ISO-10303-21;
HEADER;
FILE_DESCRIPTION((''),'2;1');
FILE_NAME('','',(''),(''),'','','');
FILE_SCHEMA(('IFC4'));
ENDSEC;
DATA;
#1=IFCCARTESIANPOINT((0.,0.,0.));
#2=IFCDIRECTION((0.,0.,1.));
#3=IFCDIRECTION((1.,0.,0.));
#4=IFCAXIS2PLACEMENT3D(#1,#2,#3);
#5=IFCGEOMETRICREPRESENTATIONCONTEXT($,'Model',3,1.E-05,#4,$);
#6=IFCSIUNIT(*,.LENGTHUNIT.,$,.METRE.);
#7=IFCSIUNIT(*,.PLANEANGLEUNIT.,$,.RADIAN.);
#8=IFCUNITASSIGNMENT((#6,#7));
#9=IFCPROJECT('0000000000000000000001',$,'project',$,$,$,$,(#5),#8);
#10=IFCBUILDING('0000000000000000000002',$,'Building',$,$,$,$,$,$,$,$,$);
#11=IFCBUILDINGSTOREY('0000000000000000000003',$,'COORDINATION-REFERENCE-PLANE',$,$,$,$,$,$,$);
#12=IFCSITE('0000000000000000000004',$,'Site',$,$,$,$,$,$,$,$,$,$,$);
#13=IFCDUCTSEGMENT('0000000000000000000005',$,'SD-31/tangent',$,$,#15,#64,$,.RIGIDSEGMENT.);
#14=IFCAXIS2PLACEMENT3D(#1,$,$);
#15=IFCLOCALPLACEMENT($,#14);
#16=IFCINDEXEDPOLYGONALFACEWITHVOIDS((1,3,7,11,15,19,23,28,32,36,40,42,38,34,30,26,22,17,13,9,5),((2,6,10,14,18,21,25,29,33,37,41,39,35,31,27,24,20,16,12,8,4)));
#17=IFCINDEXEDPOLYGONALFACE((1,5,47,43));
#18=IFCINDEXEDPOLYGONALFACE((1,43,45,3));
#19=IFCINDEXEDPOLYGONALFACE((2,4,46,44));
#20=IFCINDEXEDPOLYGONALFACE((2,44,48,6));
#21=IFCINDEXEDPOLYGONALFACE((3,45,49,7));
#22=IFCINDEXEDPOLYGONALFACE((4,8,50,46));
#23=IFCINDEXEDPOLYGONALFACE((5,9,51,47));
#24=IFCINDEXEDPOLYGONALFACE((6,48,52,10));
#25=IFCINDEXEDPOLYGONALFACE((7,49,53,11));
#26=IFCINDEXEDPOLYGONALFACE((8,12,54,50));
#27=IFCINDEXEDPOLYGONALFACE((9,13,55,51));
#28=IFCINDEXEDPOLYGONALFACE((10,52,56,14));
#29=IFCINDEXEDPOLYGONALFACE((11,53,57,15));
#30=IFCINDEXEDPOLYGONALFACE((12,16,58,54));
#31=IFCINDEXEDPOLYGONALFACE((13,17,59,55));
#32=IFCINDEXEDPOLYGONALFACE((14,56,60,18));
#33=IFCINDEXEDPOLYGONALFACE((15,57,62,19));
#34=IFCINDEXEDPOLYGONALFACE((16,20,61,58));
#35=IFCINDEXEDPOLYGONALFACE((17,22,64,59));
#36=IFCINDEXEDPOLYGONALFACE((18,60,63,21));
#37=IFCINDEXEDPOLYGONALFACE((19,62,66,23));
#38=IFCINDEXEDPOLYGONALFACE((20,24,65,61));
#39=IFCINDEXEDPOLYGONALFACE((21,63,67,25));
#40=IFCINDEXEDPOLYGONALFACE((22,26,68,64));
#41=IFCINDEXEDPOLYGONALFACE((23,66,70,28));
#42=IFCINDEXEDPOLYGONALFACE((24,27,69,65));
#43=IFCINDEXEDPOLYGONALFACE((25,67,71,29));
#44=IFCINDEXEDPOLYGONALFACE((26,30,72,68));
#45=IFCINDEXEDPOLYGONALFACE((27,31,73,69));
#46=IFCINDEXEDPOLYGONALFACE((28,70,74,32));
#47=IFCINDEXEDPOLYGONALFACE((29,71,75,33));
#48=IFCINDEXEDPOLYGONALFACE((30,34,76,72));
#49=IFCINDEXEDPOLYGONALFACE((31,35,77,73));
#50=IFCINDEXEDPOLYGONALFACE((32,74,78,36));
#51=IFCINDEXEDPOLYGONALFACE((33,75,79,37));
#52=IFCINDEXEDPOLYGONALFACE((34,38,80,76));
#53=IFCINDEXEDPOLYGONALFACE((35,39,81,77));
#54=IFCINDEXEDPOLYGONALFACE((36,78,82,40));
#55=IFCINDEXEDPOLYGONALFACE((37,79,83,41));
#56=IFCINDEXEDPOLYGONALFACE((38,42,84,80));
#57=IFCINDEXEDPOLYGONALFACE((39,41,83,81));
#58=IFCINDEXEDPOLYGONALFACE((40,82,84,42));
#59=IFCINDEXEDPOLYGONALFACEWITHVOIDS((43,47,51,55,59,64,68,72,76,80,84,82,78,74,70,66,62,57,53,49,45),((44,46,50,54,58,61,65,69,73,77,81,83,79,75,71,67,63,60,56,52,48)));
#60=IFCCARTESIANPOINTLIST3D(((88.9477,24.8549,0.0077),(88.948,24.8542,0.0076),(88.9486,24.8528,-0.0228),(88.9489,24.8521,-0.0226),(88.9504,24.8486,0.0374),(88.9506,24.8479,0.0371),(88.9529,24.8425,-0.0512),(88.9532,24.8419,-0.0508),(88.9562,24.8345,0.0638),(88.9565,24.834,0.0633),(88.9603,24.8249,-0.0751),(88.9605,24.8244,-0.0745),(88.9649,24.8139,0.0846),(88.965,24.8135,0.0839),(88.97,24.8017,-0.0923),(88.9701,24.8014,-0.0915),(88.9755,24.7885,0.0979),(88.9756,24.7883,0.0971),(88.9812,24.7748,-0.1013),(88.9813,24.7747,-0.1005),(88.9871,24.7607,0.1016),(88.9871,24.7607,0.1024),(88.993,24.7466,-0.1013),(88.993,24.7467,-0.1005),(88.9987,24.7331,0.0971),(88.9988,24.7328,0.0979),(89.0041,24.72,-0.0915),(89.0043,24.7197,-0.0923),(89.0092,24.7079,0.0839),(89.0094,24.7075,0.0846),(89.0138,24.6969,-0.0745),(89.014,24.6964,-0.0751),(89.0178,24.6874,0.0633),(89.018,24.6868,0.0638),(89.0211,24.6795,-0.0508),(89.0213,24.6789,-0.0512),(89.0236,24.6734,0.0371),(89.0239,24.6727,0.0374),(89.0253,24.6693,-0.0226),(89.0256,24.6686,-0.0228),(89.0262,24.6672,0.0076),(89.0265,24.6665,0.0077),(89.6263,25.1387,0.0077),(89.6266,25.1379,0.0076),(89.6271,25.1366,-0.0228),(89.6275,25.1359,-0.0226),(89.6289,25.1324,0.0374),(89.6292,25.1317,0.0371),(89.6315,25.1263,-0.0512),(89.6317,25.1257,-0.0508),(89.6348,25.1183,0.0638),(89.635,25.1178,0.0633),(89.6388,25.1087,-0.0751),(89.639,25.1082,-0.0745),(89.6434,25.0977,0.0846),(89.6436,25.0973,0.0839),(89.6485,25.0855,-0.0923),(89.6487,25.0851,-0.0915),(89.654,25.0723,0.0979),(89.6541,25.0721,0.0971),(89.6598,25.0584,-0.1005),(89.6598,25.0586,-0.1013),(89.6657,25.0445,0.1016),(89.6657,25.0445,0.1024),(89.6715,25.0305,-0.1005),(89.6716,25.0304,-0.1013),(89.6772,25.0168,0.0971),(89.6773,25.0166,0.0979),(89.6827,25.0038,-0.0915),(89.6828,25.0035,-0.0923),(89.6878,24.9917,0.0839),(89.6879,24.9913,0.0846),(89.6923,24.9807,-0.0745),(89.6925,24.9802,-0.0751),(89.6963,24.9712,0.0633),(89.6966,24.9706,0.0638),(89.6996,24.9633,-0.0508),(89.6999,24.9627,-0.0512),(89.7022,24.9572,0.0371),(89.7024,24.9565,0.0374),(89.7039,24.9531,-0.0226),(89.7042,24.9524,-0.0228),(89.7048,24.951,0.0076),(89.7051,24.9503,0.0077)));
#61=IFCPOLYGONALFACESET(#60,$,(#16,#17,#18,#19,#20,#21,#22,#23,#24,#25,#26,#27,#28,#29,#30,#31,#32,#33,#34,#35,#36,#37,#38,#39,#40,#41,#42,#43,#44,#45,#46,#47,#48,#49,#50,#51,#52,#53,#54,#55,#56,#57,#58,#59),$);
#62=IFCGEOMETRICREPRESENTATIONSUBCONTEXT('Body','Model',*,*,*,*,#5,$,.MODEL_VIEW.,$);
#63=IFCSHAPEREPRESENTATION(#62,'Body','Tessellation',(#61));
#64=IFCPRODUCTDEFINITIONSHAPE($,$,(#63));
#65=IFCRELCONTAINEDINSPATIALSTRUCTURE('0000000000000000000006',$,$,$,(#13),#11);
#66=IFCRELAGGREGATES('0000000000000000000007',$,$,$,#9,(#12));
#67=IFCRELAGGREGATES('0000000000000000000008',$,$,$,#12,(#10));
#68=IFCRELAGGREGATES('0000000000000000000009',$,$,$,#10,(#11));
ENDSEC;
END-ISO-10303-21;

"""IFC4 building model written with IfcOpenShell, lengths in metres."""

from ifc_helpers import new_model, si_unit, frame, origin_with_axes, place, context, subcontext, project, spatial, hollow_circle, extrude, element, save


model = new_model("IFC4")

# Units and contexts
model_context = context("Model", 3, precision=1e-05, world=origin_with_axes())
body_context_1 = subcontext(model_context, "Body", "Model", "MODEL_VIEW")
ifc_project = project(units=[si_unit("LENGTHUNIT", "METRE"), si_unit("PLANEANGLEUNIT", "RADIAN")], contexts=[model_context])

# Site, building, storey
site = spatial("IfcSite", under=ifc_project, Name="Site")
building = spatial("IfcBuilding", under=site, Name="Building")
storey = spatial("IfcBuildingStorey", under=building, Name="COORDINATION-REFERENCE-PLANE")

# Duct segment
duct_segment_1_placement = place(None, frame((89.6657, 25.0445, 0.0), z_axis=(-0.922564, -0.385845, 0.0), x_axis=(0.0, 0.0, 1.0)))
element("IfcDuctSegment", 1, at=duct_segment_1_placement, inside=storey, Name="SD-31/tangent", PredefinedType="RIGIDSEGMENT", context=body_context_1, shape_type="SweptSolid", body=[
    extrude(hollow_circle(Radius=0.1024, WallThickness=0.0008), origin_with_axes(), (0.0, 0.0, 1.0), 0.7355),
])

save(model, "model.ifc")
